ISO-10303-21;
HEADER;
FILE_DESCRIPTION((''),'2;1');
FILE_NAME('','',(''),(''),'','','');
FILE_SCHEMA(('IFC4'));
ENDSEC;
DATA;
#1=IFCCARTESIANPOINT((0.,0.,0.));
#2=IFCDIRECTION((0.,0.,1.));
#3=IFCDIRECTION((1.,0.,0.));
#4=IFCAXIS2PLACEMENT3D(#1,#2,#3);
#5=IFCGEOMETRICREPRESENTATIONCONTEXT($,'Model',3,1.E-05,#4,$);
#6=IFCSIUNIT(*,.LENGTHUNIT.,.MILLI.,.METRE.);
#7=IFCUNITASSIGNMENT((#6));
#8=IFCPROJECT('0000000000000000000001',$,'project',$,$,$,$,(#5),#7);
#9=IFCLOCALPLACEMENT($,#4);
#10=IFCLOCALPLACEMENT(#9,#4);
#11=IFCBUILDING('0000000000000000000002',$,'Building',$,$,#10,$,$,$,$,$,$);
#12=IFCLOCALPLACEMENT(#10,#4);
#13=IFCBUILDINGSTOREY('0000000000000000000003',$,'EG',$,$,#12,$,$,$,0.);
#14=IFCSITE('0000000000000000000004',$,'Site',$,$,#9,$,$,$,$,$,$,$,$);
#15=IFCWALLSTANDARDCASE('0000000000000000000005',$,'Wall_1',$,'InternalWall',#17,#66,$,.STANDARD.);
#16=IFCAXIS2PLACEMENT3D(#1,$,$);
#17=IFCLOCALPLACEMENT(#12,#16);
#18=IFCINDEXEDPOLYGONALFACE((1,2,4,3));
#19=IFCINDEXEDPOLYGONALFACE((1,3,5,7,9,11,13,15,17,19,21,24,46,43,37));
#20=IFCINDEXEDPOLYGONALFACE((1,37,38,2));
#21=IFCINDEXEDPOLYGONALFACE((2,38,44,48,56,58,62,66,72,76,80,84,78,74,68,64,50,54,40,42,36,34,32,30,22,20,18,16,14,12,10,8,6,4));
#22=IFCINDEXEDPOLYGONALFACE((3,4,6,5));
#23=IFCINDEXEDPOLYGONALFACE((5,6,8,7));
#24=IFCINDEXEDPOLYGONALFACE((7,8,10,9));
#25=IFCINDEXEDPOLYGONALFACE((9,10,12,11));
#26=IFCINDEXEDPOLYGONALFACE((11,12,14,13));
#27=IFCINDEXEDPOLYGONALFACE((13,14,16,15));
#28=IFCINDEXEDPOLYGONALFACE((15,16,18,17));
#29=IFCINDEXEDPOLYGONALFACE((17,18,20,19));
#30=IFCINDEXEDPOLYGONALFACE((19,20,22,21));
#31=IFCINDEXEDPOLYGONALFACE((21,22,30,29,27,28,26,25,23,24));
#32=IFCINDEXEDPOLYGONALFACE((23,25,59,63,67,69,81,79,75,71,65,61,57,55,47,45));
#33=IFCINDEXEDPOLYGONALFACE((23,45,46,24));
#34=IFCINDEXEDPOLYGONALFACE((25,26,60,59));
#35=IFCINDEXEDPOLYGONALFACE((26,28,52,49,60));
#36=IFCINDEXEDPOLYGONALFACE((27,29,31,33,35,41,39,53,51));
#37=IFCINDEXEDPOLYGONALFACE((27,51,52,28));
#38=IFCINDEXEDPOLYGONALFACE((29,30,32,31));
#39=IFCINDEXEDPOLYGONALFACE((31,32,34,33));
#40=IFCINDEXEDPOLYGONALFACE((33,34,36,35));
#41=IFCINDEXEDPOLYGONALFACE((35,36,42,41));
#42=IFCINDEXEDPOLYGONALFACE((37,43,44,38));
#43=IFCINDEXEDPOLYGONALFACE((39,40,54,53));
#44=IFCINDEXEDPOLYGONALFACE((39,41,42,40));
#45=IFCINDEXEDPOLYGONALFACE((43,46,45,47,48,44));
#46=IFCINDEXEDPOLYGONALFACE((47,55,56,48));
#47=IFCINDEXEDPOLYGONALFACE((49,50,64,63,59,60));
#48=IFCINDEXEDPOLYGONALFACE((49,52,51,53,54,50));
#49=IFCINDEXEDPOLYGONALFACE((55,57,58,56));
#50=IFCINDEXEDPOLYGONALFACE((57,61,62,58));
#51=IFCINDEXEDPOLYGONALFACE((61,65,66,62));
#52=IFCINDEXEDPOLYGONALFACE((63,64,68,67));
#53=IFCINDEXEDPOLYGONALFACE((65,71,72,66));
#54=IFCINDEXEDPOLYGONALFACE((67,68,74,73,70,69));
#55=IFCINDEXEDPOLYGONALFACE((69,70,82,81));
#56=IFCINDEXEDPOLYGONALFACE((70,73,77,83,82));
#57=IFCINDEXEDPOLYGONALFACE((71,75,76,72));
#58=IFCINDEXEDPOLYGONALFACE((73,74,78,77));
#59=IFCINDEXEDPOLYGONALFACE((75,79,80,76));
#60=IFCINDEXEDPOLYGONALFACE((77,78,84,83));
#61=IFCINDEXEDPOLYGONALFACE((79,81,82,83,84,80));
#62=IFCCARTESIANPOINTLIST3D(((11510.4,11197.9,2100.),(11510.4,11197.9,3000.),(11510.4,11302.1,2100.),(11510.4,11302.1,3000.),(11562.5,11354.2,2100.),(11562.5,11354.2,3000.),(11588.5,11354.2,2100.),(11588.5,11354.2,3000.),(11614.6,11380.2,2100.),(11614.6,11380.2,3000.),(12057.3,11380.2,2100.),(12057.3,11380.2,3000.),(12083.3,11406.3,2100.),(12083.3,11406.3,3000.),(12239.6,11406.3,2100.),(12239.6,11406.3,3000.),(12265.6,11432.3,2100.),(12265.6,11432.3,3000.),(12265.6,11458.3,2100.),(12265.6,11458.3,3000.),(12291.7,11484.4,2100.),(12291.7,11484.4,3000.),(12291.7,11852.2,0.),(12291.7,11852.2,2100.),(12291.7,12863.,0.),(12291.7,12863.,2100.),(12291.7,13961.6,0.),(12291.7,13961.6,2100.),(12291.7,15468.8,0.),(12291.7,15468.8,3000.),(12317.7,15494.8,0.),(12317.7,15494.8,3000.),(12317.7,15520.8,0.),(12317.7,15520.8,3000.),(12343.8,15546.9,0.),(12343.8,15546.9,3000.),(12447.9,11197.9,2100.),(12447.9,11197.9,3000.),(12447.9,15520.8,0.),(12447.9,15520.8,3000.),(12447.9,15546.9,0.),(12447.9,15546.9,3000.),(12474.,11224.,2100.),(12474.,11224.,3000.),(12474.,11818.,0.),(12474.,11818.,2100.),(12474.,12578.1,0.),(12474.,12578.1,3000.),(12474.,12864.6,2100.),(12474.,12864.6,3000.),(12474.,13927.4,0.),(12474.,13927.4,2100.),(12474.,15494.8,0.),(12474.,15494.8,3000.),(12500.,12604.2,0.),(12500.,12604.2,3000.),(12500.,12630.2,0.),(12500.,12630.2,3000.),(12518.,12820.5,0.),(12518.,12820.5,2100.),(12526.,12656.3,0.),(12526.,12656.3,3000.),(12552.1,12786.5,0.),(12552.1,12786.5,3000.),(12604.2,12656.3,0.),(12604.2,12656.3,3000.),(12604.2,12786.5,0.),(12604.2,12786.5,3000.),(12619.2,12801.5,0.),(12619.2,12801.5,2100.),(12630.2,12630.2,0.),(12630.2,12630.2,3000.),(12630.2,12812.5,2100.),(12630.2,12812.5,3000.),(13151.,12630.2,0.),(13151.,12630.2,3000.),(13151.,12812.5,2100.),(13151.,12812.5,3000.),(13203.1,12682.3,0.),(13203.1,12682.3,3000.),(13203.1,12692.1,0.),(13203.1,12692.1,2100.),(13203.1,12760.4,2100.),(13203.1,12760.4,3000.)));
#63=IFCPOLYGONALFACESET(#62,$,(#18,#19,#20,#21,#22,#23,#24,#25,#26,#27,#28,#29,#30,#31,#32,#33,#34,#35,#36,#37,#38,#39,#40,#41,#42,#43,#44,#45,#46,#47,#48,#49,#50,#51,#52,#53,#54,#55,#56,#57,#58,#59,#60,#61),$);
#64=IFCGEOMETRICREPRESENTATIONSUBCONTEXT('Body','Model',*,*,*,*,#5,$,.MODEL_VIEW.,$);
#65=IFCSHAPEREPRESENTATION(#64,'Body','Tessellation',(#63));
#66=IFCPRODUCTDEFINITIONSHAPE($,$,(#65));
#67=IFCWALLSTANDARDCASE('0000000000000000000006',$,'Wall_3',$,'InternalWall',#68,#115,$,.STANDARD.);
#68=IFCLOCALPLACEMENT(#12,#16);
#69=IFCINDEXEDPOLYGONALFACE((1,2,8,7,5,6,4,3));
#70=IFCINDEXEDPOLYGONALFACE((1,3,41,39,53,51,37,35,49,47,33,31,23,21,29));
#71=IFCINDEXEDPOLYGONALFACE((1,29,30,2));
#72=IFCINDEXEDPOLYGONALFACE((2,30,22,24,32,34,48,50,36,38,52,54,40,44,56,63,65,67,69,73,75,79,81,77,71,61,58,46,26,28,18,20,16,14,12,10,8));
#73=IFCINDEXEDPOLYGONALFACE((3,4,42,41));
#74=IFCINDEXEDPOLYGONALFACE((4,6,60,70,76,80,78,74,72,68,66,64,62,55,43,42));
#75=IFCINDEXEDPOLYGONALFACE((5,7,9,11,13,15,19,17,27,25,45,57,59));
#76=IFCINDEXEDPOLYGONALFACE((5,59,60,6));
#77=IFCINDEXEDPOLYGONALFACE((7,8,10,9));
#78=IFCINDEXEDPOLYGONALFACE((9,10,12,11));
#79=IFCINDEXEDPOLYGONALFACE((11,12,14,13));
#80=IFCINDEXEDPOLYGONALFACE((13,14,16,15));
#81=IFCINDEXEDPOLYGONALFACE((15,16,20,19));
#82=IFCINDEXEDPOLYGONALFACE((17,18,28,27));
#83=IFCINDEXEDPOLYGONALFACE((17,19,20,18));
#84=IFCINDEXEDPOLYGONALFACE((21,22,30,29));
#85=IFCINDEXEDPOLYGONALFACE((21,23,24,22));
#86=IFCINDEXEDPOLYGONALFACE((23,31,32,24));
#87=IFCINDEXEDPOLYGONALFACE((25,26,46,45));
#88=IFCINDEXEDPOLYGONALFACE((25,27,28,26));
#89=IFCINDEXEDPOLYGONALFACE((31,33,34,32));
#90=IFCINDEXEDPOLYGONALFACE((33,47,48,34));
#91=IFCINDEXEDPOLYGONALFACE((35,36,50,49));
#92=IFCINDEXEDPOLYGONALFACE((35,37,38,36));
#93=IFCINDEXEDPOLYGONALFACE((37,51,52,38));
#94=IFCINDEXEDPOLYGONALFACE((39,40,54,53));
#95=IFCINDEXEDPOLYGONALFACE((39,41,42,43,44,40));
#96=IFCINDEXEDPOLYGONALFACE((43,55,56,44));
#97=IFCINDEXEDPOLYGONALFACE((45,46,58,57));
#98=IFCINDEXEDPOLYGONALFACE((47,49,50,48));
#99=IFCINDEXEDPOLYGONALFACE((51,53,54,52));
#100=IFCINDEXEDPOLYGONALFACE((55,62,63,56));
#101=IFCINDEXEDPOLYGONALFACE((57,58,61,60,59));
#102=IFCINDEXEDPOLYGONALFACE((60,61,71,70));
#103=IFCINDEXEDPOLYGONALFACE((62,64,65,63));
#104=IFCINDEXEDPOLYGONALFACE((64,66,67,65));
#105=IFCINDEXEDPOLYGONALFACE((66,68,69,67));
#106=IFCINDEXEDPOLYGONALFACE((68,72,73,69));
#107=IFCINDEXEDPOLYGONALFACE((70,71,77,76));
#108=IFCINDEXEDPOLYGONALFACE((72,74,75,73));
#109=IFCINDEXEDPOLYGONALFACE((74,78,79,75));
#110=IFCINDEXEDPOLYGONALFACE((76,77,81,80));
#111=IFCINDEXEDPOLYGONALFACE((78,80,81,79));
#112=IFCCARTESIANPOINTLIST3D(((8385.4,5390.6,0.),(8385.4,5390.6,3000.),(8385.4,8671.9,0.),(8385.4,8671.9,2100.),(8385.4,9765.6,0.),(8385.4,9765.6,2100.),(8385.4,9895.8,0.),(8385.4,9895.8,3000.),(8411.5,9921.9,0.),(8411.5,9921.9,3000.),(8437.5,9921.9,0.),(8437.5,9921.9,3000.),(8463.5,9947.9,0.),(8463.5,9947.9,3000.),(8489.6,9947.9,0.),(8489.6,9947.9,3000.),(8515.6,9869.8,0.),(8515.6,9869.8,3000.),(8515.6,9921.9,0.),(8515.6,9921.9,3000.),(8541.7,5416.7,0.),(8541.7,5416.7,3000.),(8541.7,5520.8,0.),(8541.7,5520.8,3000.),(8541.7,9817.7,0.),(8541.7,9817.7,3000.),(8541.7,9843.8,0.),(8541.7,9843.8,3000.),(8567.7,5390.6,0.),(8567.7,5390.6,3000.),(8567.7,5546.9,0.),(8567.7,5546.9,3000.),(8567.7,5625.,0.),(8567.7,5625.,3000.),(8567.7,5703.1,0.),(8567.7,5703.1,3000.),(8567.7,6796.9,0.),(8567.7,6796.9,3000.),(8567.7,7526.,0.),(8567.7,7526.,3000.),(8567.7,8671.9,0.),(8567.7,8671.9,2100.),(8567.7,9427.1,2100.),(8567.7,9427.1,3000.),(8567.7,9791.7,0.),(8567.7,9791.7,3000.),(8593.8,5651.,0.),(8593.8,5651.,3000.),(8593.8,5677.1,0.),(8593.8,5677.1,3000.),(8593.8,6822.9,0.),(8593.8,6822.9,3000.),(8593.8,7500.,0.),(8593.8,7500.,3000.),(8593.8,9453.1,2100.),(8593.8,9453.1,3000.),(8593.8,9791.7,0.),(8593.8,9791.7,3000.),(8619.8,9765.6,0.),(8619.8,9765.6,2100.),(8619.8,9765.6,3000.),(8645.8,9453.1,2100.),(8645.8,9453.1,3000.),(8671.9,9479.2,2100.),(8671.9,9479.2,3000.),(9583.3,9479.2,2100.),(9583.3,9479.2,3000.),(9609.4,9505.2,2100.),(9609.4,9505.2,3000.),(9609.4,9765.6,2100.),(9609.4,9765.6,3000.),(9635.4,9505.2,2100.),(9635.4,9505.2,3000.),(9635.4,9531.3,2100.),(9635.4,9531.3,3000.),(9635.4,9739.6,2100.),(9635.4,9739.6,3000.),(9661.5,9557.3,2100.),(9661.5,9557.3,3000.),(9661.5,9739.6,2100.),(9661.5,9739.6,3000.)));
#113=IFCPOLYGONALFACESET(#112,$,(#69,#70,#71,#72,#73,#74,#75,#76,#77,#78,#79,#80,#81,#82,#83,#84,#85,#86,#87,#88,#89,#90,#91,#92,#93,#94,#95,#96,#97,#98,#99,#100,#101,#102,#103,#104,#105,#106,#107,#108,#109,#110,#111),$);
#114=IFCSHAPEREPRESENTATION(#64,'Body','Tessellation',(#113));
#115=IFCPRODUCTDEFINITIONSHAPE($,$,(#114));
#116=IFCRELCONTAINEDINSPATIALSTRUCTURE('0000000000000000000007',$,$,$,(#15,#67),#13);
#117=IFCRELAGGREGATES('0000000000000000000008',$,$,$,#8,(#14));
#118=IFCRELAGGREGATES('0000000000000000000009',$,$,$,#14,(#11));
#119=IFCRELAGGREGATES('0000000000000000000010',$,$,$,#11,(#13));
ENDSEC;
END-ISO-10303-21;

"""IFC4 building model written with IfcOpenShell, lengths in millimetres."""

from ifc_helpers import new_model, si_unit, frame, origin_with_axes, place, context, subcontext, project, spatial, polyline, rectangle, outline, extrude, element, save


model = new_model("IFC4")

# Units and contexts
model_context = context("Model", 3, precision=1e-05, world=origin_with_axes())
body_context = subcontext(model_context, "Body", "Model", "MODEL_VIEW")
ifc_project = project(units=[si_unit("LENGTHUNIT", "METRE", prefix="MILLI")], contexts=[model_context])

# Site, building, storey
site_placement = place(None, origin_with_axes())
site = spatial("IfcSite", under=ifc_project, at=site_placement, Name="Site")
building_placement = place(site_placement, origin_with_axes())
building = spatial("IfcBuilding", under=site, at=building_placement, Name="Building")
storey_placement = place(building_placement, origin_with_axes())
storey = spatial("IfcBuildingStorey", under=building, at=storey_placement, Name="EG", Elevation=0.0)

# Walls, openings
wall_1_placement = place(storey_placement, origin_with_axes())
wall_1 = element("IfcWallStandardCase", 1, at=wall_1_placement, inside=storey, Name="Wall_1", ObjectType="InternalWall", PredefinedType="STANDARD", context=body_context, shape_type="SweptSolid", body=[
    extrude(outline(polyline([(11510.4, 11197.9, 0.0), (11510.4, 11302.1, 0.0), (11562.5, 11354.2, 0.0), (11588.5, 11354.2, 0.0), (11614.6, 11380.2, 0.0), (12057.3, 11380.2, 0.0), (12083.3, 11406.3, 0.0), (12239.6, 11406.3, 0.0), (12265.6, 11432.3, 0.0), (12265.6, 11458.3, 0.0), (12291.7, 11484.4, 0.0), (12291.7, 15468.8, 0.0), (12317.7, 15494.8, 0.0), (12317.7, 15520.8, 0.0), (12343.8, 15546.9, 0.0), (12447.9, 15546.9, 0.0), (12447.9, 15520.8, 0.0), (12474.0, 15494.8, 0.0), (12474.0, 12864.6, 0.0), (12552.1, 12786.5, 0.0), (12604.2, 12786.5, 0.0), (12630.2, 12812.5, 0.0), (13151.0, 12812.5, 0.0), (13203.1, 12760.4, 0.0), (13203.1, 12682.3, 0.0), (13151.0, 12630.2, 0.0), (12630.2, 12630.2, 0.0), (12604.2, 12656.3, 0.0), (12526.0, 12656.3, 0.0), (12500.0, 12630.2, 0.0), (12500.0, 12604.2, 0.0), (12474.0, 12578.1, 0.0), (12474.0, 11224.0, 0.0), (12447.9, 11197.9, 0.0), (11510.4, 11197.9, 0.0)])), origin_with_axes(), (0.0, 0.0, 1.0), 3000.0),
])
opening_1_placement = place(wall_1_placement, origin_with_axes())
element("IfcOpeningElement", 2, at=opening_1_placement, inside=storey, cuts=wall_1, context=body_context, shape_type="SweptSolid", body=[
    extrude(rectangle(XDim=1079.8, YDim=1409.4), frame((12611.8, 13352.3, 0.0), z_axis=(0.0, 0.0, 1.0), x_axis=(0.184288, 0.982872, 0.0)), (0.0, 0.0, 1.0), 2100.0),
])
opening_2_placement = place(wall_1_placement, origin_with_axes())
element("IfcOpeningElement", 3, at=opening_2_placement, inside=storey, cuts=wall_1, context=body_context, shape_type="SweptSolid", body=[
    extrude(rectangle(XDim=787.1, YDim=1409.4), frame((12256.7, 11458.4, 0.0), z_axis=(0.0, 0.0, 1.0), x_axis=(0.184288, 0.982872, 0.0)), (0.0, 0.0, 1.0), 2100.0),
])
wall_2_placement = place(storey_placement, origin_with_axes())
wall_2 = element("IfcWallStandardCase", 4, at=wall_2_placement, inside=storey, Name="Wall_3", ObjectType="InternalWall", PredefinedType="STANDARD", context=body_context, shape_type="SweptSolid", body=[
    extrude(outline(polyline([(8385.4, 5390.6, 0.0), (8385.4, 9895.8, 0.0), (8411.5, 9921.9, 0.0), (8437.5, 9921.9, 0.0), (8463.5, 9947.9, 0.0), (8489.6, 9947.9, 0.0), (8515.6, 9921.9, 0.0), (8515.6, 9869.8, 0.0), (8541.7, 9843.8, 0.0), (8541.7, 9817.7, 0.0), (8567.7, 9791.7, 0.0), (8593.8, 9791.7, 0.0), (8619.8, 9765.6, 0.0), (9609.4, 9765.6, 0.0), (9635.4, 9739.6, 0.0), (9661.5, 9739.6, 0.0), (9661.5, 9557.3, 0.0), (9635.4, 9531.3, 0.0), (9635.4, 9505.2, 0.0), (9609.4, 9505.2, 0.0), (9583.3, 9479.2, 0.0), (8671.9, 9479.2, 0.0), (8645.8, 9453.1, 0.0), (8593.8, 9453.1, 0.0), (8567.7, 9427.1, 0.0), (8567.7, 7526.0, 0.0), (8593.8, 7500.0, 0.0), (8593.8, 6822.9, 0.0), (8567.7, 6796.9, 0.0), (8567.7, 5703.1, 0.0), (8593.8, 5677.1, 0.0), (8593.8, 5651.0, 0.0), (8567.7, 5625.0, 0.0), (8567.7, 5546.9, 0.0), (8541.7, 5520.8, 0.0), (8541.7, 5416.7, 0.0), (8567.7, 5390.6, 0.0), (8385.4, 5390.6, 0.0)])), origin_with_axes(), (0.0, 0.0, 1.0), 3000.0),
])
opening_3_placement = place(wall_2_placement, origin_with_axes())
element("IfcOpeningElement", 5, at=opening_3_placement, inside=storey, cuts=wall_2, context=body_context, shape_type="SweptSolid", body=[
    extrude(rectangle(XDim=1093.8, YDim=1276.0), frame((9023.4, 9218.8, 0.0), z_axis=(0.0, 0.0, 1.0), x_axis=(0.0, 1.0, 0.0)), (0.0, 0.0, 1.0), 2100.0),
])
opening_4_placement = place(wall_2_placement, origin_with_axes())
element("IfcOpeningElement", 6, at=opening_4_placement, inside=storey, cuts=wall_2, context=body_context, shape_type="SweptSolid", body=[
    extrude(rectangle(XDim=900.0, YDim=1276.0), frame((8050.2, 10554.7, 0.0), z_axis=(0.0, 0.0, 1.0), x_axis=(0.0, 1.0, 0.0)), (0.0, 0.0, 1.0), 2100.0),
])

save(model, "model.ifc")
